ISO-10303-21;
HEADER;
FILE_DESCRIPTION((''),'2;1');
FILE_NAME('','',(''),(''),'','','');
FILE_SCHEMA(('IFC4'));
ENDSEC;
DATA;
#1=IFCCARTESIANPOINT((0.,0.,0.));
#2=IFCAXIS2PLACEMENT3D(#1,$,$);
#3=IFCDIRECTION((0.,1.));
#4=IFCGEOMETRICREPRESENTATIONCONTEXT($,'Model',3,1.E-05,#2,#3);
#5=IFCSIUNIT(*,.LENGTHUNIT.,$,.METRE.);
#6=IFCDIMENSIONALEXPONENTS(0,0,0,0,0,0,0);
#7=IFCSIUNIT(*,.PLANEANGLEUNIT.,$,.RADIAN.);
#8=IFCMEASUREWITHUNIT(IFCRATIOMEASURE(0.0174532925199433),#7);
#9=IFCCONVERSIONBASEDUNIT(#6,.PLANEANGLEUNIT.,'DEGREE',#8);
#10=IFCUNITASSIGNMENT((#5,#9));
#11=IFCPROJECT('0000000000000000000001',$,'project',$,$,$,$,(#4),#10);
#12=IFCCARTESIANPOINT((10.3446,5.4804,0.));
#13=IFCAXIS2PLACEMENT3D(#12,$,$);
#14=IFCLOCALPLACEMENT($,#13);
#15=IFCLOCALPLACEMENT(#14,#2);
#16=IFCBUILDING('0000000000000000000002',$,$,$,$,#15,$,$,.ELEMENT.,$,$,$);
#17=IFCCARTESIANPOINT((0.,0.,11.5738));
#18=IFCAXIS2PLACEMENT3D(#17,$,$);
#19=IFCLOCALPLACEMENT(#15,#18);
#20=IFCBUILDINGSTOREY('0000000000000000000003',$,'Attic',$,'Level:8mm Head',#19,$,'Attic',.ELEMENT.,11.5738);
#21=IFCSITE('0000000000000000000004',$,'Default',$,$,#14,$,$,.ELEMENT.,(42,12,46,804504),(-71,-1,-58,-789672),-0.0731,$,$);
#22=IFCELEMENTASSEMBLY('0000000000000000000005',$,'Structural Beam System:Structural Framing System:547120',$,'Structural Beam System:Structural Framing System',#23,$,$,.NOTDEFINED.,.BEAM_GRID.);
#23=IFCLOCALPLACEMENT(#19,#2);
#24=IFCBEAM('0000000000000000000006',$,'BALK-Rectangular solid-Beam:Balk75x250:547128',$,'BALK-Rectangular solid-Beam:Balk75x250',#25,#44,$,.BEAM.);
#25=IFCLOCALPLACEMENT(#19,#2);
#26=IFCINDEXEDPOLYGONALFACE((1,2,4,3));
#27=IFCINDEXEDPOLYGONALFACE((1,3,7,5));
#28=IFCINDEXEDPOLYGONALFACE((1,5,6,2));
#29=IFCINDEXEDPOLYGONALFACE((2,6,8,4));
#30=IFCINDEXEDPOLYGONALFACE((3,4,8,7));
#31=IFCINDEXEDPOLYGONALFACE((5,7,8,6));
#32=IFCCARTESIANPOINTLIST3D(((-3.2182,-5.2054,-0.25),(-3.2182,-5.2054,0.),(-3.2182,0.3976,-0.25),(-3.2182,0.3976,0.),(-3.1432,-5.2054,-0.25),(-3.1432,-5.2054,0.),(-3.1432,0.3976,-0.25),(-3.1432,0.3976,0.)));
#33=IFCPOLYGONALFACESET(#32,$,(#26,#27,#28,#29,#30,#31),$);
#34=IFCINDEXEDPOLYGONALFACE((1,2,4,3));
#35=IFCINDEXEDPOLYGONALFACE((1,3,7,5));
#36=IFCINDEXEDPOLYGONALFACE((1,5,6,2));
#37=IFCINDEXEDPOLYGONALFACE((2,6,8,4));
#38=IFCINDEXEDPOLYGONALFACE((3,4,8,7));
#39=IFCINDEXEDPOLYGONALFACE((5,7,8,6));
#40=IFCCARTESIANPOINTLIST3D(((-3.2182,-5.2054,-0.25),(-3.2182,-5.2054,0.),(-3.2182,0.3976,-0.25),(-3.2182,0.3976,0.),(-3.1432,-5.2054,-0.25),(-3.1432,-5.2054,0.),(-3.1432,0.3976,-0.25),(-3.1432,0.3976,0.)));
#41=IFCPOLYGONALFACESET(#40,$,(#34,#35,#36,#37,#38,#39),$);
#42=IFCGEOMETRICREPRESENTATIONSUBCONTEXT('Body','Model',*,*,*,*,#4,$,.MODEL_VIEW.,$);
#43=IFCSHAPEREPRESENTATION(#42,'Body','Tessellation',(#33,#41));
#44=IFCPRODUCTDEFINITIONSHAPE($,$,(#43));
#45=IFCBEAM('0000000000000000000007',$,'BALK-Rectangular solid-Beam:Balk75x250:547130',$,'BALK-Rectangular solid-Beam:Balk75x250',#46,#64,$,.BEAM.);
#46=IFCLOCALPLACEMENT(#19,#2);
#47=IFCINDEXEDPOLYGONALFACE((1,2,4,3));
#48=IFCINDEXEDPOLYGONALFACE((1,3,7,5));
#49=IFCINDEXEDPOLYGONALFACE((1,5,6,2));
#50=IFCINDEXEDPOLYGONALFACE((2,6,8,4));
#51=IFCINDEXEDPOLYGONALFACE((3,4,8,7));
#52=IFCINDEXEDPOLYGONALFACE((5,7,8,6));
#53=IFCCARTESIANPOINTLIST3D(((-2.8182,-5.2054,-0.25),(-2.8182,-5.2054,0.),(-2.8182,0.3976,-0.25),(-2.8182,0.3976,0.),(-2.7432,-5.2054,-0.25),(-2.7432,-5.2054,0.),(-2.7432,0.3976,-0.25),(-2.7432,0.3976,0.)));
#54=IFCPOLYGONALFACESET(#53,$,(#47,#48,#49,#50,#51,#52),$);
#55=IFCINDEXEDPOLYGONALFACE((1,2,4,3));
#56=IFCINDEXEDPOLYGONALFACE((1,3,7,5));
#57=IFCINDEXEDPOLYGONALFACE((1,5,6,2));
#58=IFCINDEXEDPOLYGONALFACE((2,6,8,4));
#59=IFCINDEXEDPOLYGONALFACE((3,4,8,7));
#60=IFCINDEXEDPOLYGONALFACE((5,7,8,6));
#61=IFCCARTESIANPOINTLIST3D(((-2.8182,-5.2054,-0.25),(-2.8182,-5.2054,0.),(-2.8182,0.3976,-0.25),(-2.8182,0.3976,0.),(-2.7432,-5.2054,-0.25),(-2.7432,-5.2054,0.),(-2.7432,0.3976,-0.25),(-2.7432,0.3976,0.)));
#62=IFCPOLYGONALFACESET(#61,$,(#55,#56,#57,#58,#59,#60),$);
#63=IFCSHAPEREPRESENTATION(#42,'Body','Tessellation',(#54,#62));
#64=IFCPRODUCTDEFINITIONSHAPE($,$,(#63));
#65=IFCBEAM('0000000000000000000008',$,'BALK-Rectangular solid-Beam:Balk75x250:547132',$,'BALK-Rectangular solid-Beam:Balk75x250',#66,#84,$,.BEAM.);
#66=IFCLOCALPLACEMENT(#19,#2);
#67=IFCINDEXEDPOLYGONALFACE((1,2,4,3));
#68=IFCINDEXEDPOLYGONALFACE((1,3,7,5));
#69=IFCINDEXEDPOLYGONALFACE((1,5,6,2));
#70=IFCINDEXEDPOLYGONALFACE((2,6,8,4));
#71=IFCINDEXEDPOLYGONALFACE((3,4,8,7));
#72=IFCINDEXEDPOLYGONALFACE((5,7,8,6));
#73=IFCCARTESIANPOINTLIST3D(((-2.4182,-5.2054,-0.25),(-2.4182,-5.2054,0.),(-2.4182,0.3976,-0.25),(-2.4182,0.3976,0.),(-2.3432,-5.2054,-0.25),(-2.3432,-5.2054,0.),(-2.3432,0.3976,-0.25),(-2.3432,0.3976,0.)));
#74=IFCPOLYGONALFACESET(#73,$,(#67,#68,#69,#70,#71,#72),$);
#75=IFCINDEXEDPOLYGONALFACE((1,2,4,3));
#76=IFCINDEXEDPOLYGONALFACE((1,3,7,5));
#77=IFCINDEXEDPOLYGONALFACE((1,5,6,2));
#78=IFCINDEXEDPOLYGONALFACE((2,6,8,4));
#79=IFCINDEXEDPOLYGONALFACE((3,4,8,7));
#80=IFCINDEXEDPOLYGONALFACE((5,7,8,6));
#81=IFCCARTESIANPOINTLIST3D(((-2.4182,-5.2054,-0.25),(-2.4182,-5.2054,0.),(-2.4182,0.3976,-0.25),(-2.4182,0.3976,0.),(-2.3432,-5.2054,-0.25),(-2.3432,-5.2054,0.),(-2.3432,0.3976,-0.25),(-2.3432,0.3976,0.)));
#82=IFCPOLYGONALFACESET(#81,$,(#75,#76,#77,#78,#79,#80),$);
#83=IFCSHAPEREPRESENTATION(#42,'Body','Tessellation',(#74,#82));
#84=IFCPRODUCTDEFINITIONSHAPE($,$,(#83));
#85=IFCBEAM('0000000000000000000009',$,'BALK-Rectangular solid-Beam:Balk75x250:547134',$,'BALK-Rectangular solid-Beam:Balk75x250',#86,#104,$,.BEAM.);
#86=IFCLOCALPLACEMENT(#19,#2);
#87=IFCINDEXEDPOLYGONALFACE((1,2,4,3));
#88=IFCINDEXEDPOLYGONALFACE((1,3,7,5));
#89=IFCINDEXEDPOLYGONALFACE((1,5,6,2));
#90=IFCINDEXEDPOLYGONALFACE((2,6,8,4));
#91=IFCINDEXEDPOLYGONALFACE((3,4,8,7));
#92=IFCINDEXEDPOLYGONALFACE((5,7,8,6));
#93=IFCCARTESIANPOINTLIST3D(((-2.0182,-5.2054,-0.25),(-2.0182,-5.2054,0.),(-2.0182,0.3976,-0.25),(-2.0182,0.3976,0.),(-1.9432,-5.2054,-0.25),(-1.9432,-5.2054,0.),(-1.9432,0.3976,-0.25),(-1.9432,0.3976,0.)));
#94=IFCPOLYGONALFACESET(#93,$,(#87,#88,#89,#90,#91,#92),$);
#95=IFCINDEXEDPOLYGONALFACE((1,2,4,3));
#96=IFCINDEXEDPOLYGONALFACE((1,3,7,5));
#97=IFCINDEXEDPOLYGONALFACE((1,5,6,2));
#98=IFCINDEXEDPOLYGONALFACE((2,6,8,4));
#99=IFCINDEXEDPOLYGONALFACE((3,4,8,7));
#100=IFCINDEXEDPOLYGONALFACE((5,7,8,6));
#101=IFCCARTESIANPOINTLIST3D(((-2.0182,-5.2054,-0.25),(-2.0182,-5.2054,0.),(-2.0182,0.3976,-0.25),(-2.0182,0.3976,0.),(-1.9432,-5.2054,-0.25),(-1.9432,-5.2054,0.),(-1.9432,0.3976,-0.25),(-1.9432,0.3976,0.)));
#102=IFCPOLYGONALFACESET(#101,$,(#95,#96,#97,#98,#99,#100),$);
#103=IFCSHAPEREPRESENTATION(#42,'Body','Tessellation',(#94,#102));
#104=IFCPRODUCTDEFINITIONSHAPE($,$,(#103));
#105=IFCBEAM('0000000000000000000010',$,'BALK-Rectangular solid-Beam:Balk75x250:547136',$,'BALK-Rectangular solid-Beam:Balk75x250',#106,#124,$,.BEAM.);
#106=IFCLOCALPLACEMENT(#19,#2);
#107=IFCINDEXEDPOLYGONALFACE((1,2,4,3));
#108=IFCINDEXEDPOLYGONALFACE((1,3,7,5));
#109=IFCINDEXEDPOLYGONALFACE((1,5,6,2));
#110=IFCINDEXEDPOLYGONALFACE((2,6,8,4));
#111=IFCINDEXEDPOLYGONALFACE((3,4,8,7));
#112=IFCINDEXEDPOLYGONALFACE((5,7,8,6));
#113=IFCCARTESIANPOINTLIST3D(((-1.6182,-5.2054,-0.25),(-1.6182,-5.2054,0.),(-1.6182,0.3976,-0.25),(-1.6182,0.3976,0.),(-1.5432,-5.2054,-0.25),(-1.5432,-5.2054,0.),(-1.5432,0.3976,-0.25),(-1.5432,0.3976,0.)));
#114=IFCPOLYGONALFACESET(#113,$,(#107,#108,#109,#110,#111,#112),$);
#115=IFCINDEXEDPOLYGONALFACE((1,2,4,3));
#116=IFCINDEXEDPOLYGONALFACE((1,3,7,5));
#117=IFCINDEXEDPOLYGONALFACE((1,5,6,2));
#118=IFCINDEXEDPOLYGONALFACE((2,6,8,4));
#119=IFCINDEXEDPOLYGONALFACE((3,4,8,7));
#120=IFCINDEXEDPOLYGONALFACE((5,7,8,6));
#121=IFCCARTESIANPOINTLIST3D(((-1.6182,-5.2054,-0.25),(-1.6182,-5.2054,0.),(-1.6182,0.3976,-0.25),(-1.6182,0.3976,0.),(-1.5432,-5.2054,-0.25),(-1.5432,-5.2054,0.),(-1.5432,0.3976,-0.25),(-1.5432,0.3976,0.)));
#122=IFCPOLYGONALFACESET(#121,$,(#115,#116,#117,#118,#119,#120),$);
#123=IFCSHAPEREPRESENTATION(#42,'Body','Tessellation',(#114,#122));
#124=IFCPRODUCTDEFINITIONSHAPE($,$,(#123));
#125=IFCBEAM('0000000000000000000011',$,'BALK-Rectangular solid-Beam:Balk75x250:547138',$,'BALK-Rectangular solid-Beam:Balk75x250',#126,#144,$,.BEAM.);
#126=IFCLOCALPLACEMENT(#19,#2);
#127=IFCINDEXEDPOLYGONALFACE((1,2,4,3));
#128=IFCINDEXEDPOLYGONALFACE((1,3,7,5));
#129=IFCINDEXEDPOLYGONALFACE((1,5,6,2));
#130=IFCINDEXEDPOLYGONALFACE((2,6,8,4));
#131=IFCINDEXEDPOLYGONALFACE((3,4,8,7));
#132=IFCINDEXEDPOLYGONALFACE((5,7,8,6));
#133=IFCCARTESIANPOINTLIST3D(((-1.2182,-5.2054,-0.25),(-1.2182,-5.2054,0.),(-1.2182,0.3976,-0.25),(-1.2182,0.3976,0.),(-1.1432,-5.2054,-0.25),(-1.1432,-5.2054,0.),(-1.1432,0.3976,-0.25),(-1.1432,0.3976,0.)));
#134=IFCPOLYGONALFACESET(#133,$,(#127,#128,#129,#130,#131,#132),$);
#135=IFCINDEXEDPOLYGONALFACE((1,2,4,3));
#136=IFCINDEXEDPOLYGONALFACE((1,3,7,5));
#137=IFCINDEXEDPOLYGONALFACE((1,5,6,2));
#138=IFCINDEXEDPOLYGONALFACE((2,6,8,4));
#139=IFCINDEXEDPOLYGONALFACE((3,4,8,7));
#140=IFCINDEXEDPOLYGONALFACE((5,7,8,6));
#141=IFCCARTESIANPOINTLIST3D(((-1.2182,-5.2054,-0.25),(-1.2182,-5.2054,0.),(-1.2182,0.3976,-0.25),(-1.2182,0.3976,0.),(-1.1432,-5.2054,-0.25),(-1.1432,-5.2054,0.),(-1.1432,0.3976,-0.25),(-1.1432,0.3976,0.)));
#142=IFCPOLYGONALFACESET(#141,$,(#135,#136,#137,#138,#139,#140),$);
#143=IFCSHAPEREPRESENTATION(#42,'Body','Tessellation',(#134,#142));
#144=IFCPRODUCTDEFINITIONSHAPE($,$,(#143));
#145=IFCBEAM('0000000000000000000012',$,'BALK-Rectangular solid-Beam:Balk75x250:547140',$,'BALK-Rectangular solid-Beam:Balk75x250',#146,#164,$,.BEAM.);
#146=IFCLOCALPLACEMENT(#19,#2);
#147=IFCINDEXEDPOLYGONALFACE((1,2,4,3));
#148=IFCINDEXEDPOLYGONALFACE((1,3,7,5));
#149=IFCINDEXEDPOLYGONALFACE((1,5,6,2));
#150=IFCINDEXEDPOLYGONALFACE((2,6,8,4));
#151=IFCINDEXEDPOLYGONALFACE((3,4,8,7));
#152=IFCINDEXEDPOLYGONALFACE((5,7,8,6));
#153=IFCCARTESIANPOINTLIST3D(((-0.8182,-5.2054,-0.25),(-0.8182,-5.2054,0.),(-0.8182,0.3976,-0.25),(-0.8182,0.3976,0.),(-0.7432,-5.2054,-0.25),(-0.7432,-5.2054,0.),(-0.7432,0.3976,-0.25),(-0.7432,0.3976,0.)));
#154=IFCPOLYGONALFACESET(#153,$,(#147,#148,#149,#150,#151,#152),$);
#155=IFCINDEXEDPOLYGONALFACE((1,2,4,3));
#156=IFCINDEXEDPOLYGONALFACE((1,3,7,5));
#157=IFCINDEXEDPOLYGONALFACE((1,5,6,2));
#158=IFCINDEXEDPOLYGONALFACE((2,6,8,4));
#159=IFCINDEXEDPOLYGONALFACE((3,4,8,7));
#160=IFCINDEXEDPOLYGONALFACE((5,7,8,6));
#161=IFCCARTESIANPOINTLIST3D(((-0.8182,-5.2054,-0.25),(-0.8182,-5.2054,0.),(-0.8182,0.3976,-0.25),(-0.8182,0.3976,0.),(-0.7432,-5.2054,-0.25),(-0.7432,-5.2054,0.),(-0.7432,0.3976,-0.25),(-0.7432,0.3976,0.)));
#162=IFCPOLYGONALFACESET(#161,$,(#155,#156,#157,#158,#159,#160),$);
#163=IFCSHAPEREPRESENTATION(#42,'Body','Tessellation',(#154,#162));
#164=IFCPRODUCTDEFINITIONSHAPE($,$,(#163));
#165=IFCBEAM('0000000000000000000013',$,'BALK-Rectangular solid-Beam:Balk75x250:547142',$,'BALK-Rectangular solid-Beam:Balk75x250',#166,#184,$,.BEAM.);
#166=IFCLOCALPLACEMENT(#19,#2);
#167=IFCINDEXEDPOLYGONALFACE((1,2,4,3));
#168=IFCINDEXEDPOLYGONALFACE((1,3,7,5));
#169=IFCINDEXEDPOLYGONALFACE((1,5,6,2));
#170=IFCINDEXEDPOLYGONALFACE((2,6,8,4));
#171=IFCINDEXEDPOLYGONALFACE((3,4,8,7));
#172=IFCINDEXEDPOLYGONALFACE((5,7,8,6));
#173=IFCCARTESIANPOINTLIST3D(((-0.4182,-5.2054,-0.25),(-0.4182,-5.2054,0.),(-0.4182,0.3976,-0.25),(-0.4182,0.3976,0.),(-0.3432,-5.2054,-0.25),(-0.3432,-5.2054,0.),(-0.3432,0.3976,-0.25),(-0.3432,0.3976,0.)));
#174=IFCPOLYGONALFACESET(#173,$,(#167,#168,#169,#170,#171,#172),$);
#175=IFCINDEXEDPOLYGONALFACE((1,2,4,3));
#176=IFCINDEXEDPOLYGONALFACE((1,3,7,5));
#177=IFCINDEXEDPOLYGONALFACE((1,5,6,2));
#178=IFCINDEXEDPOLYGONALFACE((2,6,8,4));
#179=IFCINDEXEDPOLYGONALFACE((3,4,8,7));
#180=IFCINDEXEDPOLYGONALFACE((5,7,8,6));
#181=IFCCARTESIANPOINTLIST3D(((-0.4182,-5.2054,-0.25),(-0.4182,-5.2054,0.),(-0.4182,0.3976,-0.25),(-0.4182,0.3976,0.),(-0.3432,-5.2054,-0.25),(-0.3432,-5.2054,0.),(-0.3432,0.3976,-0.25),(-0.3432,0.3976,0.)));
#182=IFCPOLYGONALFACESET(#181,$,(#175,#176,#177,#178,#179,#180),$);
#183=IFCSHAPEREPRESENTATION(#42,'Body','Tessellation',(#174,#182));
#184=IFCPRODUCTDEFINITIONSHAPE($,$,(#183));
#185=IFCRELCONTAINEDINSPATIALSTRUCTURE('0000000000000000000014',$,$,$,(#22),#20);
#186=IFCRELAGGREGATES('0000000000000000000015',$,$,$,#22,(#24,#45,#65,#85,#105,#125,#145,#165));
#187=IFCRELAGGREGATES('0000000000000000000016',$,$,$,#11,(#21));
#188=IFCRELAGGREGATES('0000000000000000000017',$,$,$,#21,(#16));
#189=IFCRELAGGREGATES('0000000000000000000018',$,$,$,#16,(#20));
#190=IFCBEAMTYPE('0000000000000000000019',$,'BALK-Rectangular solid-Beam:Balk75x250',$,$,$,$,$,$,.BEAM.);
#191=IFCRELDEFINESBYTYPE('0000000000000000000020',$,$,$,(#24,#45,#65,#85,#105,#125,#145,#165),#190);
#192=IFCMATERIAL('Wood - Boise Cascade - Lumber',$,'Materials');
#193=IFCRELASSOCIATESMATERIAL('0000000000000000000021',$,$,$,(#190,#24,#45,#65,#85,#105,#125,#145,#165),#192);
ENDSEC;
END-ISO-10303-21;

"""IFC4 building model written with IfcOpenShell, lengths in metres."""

from ifc_helpers import new_model, entity, si_unit, converted_unit, direction, frame, frame_2d, origin, origin_2d_with_axis, place, context, subcontext, project, spatial, rectangle, extrude, source, transform, mapped, material, material_profile, profile_set, profile_usage, type_object, type_shapes, element, aggregate, save


model = new_model("IFC4")

# Units and contexts
model_context = context("Model", 3, precision=1e-05, world=origin(), true_north=direction((0.0, 1.0)))
body_context = subcontext(model_context, "Body", "Model", "MODEL_VIEW")
ifc_project = project(units=[si_unit("LENGTHUNIT", "METRE"), converted_unit("PLANEANGLEUNIT", "DEGREE", entity("IfcRatioMeasure", 0.0174532925199433), si_unit("PLANEANGLEUNIT", "RADIAN"), dimensions=[0, 0, 0, 0, 0, 0, 0])], contexts=[model_context])

# Site, building, storey
site_placement = place(None, frame((10.3446, 5.4804, 0.0)))
site = spatial("IfcSite", under=ifc_project, at=site_placement, Name="Default", CompositionType="ELEMENT", RefLatitude=(42, 12, 46, 804504), RefLongitude=(-71, -1, -58, -789672), RefElevation=-0.0731)
building_placement = place(site_placement, origin())
building = spatial("IfcBuilding", under=site, at=building_placement, CompositionType="ELEMENT")
storey_placement = place(building_placement, frame((0.0, 0.0, 11.5738)))
storey = spatial("IfcBuildingStorey", under=building, at=storey_placement, Name="Attic", ObjectType="Level:8mm Head", LongName="Attic", CompositionType="ELEMENT", Elevation=11.5738)

# Shared definitions
ifc_material = material(Name="Wood - Boise Cascade - Lumber", Category="Materials")
ifc_material_profile = material_profile(ifc_material, rectangle(XDim=0.25, YDim=0.075, at=frame_2d((0.0, 0.0), x_axis=(1.0, 0.0))), Name="Balk75x250")
ifc_profile_set = profile_set([ifc_material_profile], Name="Balk75x250")

# Element assembly, beams
assembly_1_placement = place(storey_placement, origin())
assembly_1 = element("IfcElementAssembly", 1, at=assembly_1_placement, inside=storey, Name="Structural Beam System:Structural Framing System:547120", ObjectType="Structural Beam System:Structural Framing System", AssemblyPlace="NOTDEFINED", PredefinedType="BEAM_GRID")
beam_type_1 = type_object("IfcBeamType", Name="BALK-Rectangular solid-Beam:Balk75x250", PredefinedType="BEAM", material=ifc_profile_set)
shared_shape_1 = source(origin(), body_context, "Body", "SweptSolid", [
    extrude(rectangle(XDim=0.25, YDim=0.075, at=origin_2d_with_axis()), frame((-2.6953, 0.0, 0.0), z_axis=(1.0, 0.0, 0.0), x_axis=(0.0, 0.0, -1.0)), (0.0, 0.0, 1.0), 5.603),
    extrude(rectangle(XDim=0.25, YDim=0.075, at=origin_2d_with_axis()), frame((-2.6953, 0.0, 0.0), z_axis=(1.0, 0.0, 0.0), x_axis=(0.0, 0.0, -1.0)), (0.0, 0.0, 1.0), 5.603),
])
type_shapes(beam_type_1, [shared_shape_1])
ifc_profile_usage_1 = profile_usage(ifc_profile_set, cardinal=8)
beam_1_placement = place(assembly_1_placement, frame((-3.1807, -2.5102, -0.125), z_axis=(0.0, 0.0, 1.0), x_axis=(0.0, 1.0, 0.0)))
beam_1 = element("IfcBeam", 2, at=beam_1_placement, type_object=beam_type_1, material=ifc_profile_usage_1, Name="BALK-Rectangular solid-Beam:Balk75x250:547128", ObjectType="BALK-Rectangular solid-Beam:Balk75x250", PredefinedType="BEAM", context=body_context, shape_type="MappedRepresentation", body=[
    mapped(shared_shape_1, transform((0.0, 0.0, 0.0), scale=1.0)),
])
ifc_profile_usage_2 = profile_usage(ifc_profile_set, cardinal=8)
beam_2_placement = place(assembly_1_placement, frame((-2.7807, -2.5102, -0.125), z_axis=(0.0, 0.0, 1.0), x_axis=(0.0, 1.0, 0.0)))
beam_2 = element("IfcBeam", 3, at=beam_2_placement, type_object=beam_type_1, material=ifc_profile_usage_2, Name="BALK-Rectangular solid-Beam:Balk75x250:547130", ObjectType="BALK-Rectangular solid-Beam:Balk75x250", PredefinedType="BEAM", context=body_context, shape_type="MappedRepresentation", body=[
    mapped(shared_shape_1, transform((0.0, 0.0, 0.0), scale=1.0)),
])
ifc_profile_usage_3 = profile_usage(ifc_profile_set, cardinal=8)
beam_3_placement = place(assembly_1_placement, frame((-2.3807, -2.5102, -0.125), z_axis=(0.0, 0.0, 1.0), x_axis=(0.0, 1.0, 0.0)))
beam_3 = element("IfcBeam", 4, at=beam_3_placement, type_object=beam_type_1, material=ifc_profile_usage_3, Name="BALK-Rectangular solid-Beam:Balk75x250:547132", ObjectType="BALK-Rectangular solid-Beam:Balk75x250", PredefinedType="BEAM", context=body_context, shape_type="MappedRepresentation", body=[
    mapped(shared_shape_1, transform((0.0, 0.0, 0.0), scale=1.0)),
])
ifc_profile_usage_4 = profile_usage(ifc_profile_set, cardinal=8)
beam_4_placement = place(assembly_1_placement, frame((-1.9807, -2.5102, -0.125), z_axis=(0.0, 0.0, 1.0), x_axis=(0.0, 1.0, 0.0)))
beam_4 = element("IfcBeam", 5, at=beam_4_placement, type_object=beam_type_1, material=ifc_profile_usage_4, Name="BALK-Rectangular solid-Beam:Balk75x250:547134", ObjectType="BALK-Rectangular solid-Beam:Balk75x250", PredefinedType="BEAM", context=body_context, shape_type="MappedRepresentation", body=[
    mapped(shared_shape_1, transform((0.0, 0.0, 0.0), scale=1.0)),
])
ifc_profile_usage_5 = profile_usage(ifc_profile_set, cardinal=8)
beam_5_placement = place(assembly_1_placement, frame((-1.5807, -2.5102, -0.125), z_axis=(0.0, 0.0, 1.0), x_axis=(0.0, 1.0, 0.0)))
beam_5 = element("IfcBeam", 6, at=beam_5_placement, type_object=beam_type_1, material=ifc_profile_usage_5, Name="BALK-Rectangular solid-Beam:Balk75x250:547136", ObjectType="BALK-Rectangular solid-Beam:Balk75x250", PredefinedType="BEAM", context=body_context, shape_type="MappedRepresentation", body=[
    mapped(shared_shape_1, transform((0.0, 0.0, 0.0), scale=1.0)),
])
ifc_profile_usage_6 = profile_usage(ifc_profile_set, cardinal=8)
beam_6_placement = place(assembly_1_placement, frame((-1.1807, -2.5102, -0.125), z_axis=(0.0, 0.0, 1.0), x_axis=(0.0, 1.0, 0.0)))
beam_6 = element("IfcBeam", 7, at=beam_6_placement, type_object=beam_type_1, material=ifc_profile_usage_6, Name="BALK-Rectangular solid-Beam:Balk75x250:547138", ObjectType="BALK-Rectangular solid-Beam:Balk75x250", PredefinedType="BEAM", context=body_context, shape_type="MappedRepresentation", body=[
    mapped(shared_shape_1, transform((0.0, 0.0, 0.0), scale=1.0)),
])
ifc_profile_usage_7 = profile_usage(ifc_profile_set, cardinal=8)
beam_7_placement = place(assembly_1_placement, frame((-0.7807, -2.5102, -0.125), z_axis=(0.0, 0.0, 1.0), x_axis=(0.0, 1.0, 0.0)))
beam_7 = element("IfcBeam", 8, at=beam_7_placement, type_object=beam_type_1, material=ifc_profile_usage_7, Name="BALK-Rectangular solid-Beam:Balk75x250:547140", ObjectType="BALK-Rectangular solid-Beam:Balk75x250", PredefinedType="BEAM", context=body_context, shape_type="MappedRepresentation", body=[
    mapped(shared_shape_1, transform((0.0, 0.0, 0.0), scale=1.0)),
])
ifc_profile_usage_8 = profile_usage(ifc_profile_set, cardinal=8)
beam_8_placement = place(assembly_1_placement, frame((-0.3807, -2.5102, -0.125), z_axis=(0.0, 0.0, 1.0), x_axis=(0.0, 1.0, 0.0)))
beam_8 = element("IfcBeam", 9, at=beam_8_placement, type_object=beam_type_1, material=ifc_profile_usage_8, Name="BALK-Rectangular solid-Beam:Balk75x250:547142", ObjectType="BALK-Rectangular solid-Beam:Balk75x250", PredefinedType="BEAM", context=body_context, shape_type="MappedRepresentation", body=[
    mapped(shared_shape_1, transform((0.0, 0.0, 0.0), scale=1.0)),
])
aggregate(assembly_1, [beam_1, beam_2, beam_3, beam_4, beam_5, beam_6, beam_7, beam_8])

save(model, "model.ifc")
